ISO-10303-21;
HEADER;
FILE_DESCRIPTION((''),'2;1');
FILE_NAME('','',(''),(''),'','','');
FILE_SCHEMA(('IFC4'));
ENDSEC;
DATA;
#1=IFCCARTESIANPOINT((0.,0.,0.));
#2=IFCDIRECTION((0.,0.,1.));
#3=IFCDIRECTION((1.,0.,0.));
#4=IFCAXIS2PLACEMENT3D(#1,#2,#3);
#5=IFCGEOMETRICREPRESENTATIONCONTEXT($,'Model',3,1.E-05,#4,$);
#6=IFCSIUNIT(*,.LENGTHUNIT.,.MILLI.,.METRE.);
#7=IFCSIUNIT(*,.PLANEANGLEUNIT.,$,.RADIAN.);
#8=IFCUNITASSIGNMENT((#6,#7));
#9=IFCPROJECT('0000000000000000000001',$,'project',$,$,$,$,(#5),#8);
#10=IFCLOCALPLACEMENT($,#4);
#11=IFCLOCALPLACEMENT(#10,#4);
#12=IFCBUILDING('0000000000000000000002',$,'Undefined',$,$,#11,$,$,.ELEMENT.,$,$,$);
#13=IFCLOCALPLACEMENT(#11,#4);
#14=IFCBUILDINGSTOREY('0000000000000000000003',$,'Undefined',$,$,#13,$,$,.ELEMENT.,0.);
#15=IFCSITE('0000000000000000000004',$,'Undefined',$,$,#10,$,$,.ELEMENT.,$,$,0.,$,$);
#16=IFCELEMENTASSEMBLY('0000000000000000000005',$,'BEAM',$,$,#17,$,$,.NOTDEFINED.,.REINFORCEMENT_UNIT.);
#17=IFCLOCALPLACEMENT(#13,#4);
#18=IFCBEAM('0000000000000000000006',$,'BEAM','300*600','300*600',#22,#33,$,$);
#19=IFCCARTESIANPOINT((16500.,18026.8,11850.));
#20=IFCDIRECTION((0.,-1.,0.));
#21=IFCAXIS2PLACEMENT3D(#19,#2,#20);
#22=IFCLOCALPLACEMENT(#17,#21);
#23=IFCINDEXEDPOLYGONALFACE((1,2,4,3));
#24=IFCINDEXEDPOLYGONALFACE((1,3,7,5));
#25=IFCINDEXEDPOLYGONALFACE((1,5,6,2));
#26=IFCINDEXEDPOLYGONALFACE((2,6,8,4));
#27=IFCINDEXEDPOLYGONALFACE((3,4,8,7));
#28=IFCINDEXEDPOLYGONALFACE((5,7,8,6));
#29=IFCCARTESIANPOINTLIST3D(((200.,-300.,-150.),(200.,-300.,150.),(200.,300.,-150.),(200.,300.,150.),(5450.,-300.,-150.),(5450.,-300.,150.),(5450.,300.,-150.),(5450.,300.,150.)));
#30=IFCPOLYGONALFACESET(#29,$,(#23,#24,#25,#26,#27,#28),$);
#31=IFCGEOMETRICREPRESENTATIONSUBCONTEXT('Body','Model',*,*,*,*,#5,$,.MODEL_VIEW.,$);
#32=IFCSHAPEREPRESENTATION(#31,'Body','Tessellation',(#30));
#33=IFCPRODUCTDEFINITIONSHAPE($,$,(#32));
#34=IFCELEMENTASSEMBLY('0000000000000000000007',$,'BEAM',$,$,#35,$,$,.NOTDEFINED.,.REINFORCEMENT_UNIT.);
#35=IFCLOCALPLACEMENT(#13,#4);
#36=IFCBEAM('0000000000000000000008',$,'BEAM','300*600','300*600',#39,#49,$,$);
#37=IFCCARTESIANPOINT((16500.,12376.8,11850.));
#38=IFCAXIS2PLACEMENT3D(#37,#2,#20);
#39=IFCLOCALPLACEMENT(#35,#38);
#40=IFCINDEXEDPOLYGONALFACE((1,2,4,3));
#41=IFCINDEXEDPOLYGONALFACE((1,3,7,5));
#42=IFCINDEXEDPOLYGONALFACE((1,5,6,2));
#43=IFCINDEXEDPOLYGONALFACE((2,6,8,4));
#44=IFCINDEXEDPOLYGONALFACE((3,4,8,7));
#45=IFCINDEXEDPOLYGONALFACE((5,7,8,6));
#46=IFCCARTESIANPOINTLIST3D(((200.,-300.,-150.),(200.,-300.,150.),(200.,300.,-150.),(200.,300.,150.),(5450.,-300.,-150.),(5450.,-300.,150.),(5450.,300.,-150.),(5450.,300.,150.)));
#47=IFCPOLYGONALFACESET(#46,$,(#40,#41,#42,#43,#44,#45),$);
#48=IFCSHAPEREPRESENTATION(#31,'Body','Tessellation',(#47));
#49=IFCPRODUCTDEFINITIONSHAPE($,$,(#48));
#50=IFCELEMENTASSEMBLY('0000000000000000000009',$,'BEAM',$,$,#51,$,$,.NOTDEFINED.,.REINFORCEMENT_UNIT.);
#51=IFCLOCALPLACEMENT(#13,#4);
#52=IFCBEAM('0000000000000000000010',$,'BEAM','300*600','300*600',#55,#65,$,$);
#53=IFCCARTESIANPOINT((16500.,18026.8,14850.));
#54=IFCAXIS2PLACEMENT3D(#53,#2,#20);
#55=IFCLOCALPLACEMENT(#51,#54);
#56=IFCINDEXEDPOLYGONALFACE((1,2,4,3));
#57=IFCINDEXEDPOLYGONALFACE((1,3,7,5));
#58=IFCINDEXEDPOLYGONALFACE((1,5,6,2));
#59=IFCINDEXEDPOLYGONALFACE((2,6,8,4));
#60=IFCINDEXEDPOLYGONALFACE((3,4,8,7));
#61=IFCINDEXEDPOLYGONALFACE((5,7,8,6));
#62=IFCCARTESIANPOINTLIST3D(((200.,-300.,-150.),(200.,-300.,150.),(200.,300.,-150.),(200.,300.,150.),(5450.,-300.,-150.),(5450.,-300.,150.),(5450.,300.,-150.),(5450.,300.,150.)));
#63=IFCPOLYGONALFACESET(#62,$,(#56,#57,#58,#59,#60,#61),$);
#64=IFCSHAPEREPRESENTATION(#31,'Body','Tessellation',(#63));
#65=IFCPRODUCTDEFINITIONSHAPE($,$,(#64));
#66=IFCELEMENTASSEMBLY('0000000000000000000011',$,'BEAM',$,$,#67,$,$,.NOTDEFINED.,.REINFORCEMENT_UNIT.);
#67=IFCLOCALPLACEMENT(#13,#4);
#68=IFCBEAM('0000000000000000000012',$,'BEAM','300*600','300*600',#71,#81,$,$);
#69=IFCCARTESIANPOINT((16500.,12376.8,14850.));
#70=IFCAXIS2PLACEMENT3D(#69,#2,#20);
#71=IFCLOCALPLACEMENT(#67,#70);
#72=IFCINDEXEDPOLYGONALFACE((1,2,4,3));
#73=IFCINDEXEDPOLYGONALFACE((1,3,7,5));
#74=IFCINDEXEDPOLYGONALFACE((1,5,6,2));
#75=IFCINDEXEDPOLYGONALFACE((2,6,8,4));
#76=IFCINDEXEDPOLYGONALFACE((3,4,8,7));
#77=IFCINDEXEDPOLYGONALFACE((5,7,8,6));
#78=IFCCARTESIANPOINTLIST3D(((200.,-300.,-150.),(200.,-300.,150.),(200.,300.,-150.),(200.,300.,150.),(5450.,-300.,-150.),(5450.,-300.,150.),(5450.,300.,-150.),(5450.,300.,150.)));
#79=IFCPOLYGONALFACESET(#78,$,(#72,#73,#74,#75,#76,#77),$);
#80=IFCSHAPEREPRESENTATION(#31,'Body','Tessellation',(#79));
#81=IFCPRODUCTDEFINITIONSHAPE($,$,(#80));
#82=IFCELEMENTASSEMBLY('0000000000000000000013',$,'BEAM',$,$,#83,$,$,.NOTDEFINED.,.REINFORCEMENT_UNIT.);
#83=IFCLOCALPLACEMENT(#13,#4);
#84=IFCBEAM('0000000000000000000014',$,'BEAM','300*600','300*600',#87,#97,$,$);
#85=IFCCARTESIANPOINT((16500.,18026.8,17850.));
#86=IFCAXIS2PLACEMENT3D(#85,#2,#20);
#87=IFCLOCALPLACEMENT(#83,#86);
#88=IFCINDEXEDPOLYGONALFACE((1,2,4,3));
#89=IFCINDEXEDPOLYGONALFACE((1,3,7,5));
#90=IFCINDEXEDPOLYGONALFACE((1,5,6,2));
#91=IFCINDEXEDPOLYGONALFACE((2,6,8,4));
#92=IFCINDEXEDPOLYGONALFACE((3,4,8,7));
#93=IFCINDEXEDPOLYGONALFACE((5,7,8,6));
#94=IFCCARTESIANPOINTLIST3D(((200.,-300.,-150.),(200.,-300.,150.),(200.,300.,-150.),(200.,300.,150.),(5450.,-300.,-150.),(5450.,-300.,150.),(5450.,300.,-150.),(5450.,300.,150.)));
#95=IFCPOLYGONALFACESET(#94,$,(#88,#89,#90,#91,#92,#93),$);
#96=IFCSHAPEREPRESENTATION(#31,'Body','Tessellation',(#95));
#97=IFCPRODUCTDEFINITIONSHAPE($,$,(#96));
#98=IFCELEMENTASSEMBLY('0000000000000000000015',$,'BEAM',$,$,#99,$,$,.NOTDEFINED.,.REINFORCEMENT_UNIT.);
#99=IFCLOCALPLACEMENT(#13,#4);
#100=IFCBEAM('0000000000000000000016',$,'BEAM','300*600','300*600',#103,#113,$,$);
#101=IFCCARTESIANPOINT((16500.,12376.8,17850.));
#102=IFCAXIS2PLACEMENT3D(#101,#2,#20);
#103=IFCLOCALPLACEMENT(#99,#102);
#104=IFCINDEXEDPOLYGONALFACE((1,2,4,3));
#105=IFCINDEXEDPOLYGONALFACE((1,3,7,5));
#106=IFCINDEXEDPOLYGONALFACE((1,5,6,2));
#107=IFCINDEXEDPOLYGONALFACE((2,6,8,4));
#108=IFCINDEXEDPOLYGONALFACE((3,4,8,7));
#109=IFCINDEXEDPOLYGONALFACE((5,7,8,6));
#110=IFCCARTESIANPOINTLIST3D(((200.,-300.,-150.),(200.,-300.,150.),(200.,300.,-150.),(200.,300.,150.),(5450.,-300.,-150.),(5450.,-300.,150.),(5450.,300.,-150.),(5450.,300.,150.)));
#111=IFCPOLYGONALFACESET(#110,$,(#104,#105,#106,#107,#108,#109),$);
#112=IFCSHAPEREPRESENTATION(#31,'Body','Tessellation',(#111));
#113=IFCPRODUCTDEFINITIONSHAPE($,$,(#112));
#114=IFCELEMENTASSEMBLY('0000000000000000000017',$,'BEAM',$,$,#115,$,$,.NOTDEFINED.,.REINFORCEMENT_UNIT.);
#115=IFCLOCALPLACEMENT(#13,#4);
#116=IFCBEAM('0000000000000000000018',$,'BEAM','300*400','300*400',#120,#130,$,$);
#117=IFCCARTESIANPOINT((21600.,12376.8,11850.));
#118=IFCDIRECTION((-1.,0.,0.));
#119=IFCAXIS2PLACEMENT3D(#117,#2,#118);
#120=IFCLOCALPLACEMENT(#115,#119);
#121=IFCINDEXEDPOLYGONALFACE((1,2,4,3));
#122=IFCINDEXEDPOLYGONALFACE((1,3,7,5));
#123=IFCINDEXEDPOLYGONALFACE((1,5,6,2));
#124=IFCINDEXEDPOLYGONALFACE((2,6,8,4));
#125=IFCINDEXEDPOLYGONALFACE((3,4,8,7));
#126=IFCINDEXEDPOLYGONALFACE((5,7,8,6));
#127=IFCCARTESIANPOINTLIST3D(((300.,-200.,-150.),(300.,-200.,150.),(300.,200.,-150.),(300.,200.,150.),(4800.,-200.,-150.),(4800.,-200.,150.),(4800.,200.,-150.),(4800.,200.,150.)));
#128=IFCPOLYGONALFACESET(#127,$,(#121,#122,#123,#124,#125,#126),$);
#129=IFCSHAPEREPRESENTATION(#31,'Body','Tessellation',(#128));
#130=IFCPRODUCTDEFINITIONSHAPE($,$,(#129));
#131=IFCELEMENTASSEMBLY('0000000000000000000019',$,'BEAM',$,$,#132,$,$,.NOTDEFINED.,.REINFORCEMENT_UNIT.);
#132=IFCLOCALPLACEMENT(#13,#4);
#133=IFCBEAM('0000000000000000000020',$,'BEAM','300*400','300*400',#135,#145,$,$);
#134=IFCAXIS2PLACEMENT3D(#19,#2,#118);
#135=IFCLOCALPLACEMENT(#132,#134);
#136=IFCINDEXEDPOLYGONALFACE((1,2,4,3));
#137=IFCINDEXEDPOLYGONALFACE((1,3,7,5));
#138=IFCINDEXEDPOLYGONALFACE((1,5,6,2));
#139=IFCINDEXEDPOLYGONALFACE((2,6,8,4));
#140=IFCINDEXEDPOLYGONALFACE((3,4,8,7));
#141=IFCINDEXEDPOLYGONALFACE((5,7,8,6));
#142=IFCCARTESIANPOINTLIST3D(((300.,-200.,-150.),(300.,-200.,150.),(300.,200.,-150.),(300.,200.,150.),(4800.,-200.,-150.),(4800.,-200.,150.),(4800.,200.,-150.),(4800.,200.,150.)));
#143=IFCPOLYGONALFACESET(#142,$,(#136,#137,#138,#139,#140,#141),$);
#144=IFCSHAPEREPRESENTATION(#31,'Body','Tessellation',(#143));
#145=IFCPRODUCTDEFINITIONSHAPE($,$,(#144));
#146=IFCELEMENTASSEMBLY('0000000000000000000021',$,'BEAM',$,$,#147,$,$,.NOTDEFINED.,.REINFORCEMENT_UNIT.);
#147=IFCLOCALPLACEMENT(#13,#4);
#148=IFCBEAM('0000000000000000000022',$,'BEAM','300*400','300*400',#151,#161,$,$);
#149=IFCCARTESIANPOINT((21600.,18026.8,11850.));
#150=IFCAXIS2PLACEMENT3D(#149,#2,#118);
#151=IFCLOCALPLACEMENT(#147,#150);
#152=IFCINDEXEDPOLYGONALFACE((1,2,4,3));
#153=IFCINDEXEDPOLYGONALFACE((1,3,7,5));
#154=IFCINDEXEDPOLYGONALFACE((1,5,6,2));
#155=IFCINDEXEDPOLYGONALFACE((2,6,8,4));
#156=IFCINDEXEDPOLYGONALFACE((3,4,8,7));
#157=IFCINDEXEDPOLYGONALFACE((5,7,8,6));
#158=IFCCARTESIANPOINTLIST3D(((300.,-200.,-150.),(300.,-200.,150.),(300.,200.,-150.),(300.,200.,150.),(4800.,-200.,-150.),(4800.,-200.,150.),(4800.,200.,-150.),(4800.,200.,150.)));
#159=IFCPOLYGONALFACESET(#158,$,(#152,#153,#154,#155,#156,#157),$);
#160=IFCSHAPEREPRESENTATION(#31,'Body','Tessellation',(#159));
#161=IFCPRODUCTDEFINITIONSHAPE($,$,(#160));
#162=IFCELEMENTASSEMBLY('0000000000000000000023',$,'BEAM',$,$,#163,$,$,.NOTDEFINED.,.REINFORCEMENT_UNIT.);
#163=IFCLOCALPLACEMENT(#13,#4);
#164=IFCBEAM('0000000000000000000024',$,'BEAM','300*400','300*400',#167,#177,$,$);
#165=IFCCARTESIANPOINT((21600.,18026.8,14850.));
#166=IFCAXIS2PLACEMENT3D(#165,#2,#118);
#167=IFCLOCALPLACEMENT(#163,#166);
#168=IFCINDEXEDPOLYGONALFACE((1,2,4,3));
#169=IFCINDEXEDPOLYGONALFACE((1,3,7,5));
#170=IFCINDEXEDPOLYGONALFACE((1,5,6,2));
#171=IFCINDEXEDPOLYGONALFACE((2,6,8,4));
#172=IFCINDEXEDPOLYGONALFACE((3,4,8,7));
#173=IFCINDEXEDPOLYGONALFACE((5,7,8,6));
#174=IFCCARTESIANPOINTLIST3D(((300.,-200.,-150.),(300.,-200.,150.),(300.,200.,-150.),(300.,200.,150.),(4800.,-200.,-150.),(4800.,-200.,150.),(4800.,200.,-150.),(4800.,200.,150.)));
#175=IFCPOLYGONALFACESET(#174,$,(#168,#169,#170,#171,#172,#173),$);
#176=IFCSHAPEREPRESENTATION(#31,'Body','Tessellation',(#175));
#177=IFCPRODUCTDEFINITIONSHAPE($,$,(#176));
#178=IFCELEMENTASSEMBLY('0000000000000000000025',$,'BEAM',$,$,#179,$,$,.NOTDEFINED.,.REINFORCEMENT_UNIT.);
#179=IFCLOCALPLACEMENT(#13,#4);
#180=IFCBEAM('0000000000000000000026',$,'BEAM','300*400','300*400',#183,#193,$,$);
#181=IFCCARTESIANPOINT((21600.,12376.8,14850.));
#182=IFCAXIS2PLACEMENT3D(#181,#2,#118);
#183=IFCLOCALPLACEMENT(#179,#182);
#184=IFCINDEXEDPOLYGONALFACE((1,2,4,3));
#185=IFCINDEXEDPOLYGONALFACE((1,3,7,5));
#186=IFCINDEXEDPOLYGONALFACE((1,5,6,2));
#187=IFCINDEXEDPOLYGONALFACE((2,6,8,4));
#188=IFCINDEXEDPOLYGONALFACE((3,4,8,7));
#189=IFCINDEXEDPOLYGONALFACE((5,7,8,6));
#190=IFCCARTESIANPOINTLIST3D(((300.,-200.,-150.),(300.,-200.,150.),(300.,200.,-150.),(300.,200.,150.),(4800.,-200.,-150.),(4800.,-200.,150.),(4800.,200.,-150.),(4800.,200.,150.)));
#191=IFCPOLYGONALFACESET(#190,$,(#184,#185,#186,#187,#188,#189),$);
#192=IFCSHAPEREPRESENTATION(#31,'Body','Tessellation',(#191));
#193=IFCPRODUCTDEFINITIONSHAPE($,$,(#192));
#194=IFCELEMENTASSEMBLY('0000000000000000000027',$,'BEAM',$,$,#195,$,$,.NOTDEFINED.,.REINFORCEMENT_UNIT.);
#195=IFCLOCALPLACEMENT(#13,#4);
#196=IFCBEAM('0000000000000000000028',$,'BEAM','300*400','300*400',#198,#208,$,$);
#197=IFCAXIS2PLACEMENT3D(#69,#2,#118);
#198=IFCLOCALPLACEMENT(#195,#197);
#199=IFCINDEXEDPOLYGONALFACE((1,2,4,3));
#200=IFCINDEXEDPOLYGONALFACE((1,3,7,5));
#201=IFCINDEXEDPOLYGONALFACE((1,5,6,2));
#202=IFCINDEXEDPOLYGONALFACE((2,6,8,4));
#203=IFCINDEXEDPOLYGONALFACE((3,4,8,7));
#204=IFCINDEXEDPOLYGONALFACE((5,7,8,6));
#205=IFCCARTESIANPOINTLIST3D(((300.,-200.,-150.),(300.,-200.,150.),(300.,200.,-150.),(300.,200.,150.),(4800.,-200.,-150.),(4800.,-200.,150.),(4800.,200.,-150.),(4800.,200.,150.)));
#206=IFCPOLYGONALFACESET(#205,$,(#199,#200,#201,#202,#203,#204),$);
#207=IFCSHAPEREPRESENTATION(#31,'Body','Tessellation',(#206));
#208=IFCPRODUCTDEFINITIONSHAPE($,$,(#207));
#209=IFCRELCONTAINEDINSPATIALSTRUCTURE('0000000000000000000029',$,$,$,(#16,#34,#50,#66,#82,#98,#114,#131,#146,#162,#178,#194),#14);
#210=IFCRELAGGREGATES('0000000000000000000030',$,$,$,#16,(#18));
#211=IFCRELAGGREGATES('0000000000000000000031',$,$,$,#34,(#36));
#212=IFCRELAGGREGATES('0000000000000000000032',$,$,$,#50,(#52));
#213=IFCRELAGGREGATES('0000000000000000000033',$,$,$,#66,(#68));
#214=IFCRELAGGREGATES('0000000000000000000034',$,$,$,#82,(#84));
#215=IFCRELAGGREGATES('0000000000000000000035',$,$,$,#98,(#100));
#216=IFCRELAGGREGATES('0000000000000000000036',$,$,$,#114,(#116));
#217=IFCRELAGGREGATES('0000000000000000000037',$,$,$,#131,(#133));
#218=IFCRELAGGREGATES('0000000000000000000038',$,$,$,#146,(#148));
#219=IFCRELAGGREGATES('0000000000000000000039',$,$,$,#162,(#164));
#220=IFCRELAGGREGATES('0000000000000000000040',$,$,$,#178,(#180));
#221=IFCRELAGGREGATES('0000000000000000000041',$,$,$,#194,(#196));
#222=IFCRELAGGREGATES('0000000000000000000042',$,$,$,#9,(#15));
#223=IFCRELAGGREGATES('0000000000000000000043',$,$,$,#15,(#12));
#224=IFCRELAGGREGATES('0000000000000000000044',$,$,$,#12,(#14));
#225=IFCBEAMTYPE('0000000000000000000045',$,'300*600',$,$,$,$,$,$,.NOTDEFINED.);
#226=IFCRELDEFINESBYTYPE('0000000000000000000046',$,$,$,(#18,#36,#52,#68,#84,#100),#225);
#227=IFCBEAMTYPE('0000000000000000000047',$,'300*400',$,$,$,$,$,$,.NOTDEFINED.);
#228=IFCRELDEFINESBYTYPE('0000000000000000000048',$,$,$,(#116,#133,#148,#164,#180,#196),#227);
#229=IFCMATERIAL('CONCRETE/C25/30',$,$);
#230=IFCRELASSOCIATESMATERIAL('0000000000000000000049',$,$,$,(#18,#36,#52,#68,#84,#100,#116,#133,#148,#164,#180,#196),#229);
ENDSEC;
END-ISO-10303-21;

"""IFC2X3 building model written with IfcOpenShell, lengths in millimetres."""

from ifc_helpers import new_model, si_unit, frame, origin_with_axes, origin_2d_with_axis, place, context, subcontext, project, spatial, rectangle, extrude, material, type_object, element, aggregate, save


model = new_model("IFC2X3")

# Units and contexts
model_context = context("Model", 3, precision=1e-05, world=origin_with_axes())
body_context = subcontext(model_context, "Body", "Model", "MODEL_VIEW")
ifc_project = project(units=[si_unit("LENGTHUNIT", "METRE", prefix="MILLI"), si_unit("PLANEANGLEUNIT", "RADIAN")], contexts=[model_context])

# Site, building, storey
site_placement = place(None, origin_with_axes())
site = spatial("IfcSite", under=ifc_project, at=site_placement, Name="Undefined", CompositionType="ELEMENT", RefElevation=0.0)
building_placement = place(site_placement, origin_with_axes())
building = spatial("IfcBuilding", under=site, at=building_placement, Name="Undefined", CompositionType="ELEMENT")
storey_placement = place(building_placement, origin_with_axes())
storey = spatial("IfcBuildingStorey", under=building, at=storey_placement, Name="Undefined", CompositionType="ELEMENT", Elevation=0.0)

# Shared definitions
ifc_material = material(Name="CONCRETE/C25/30")

# Element assemblies, beams
assembly_1_placement = place(storey_placement, origin_with_axes())
assembly_1 = element("IfcElementAssembly", 1, at=assembly_1_placement, inside=storey, Name="BEAM", AssemblyPlace="NOTDEFINED", PredefinedType="REINFORCEMENT_UNIT")
beam_type_1 = type_object("IfcBeamType", Name="300*600", PredefinedType="NOTDEFINED")
beam_1_placement = place(assembly_1_placement, frame((16500.0, 18026.8, 11850.0), z_axis=(0.0, 0.0, 1.0), x_axis=(0.0, -1.0, 0.0)))
beam_1 = element("IfcBeam", 2, at=beam_1_placement, type_object=beam_type_1, material=ifc_material, Name="BEAM", Description="300*600", ObjectType="300*600", context=body_context, shape_type="SweptSolid", body=[
    extrude(rectangle(XDim=600.0, YDim=300.0, at=origin_2d_with_axis()), frame((5450.0, 0.0, 0.0), z_axis=(-1.0, 0.0, 0.0), x_axis=(0.0, -1.0, 0.0)), (0.0, 0.0, 1.0), 5250.0),
])
aggregate(assembly_1, [beam_1])
assembly_2_placement = place(storey_placement, origin_with_axes())
assembly_2 = element("IfcElementAssembly", 3, at=assembly_2_placement, inside=storey, Name="BEAM", AssemblyPlace="NOTDEFINED", PredefinedType="REINFORCEMENT_UNIT")
beam_2_placement = place(assembly_2_placement, frame((16500.0, 12376.8, 11850.0), z_axis=(0.0, 0.0, 1.0), x_axis=(0.0, -1.0, 0.0)))
beam_2 = element("IfcBeam", 4, at=beam_2_placement, type_object=beam_type_1, material=ifc_material, Name="BEAM", Description="300*600", ObjectType="300*600", context=body_context, shape_type="SweptSolid", body=[
    extrude(rectangle(XDim=600.0, YDim=300.0, at=origin_2d_with_axis()), frame((5450.0, 0.0, 0.0), z_axis=(-1.0, 0.0, 0.0), x_axis=(0.0, -1.0, 0.0)), (0.0, 0.0, 1.0), 5250.0),
])
aggregate(assembly_2, [beam_2])
assembly_3_placement = place(storey_placement, origin_with_axes())
assembly_3 = element("IfcElementAssembly", 5, at=assembly_3_placement, inside=storey, Name="BEAM", AssemblyPlace="NOTDEFINED", PredefinedType="REINFORCEMENT_UNIT")
beam_3_placement = place(assembly_3_placement, frame((16500.0, 18026.8, 14850.0), z_axis=(0.0, 0.0, 1.0), x_axis=(0.0, -1.0, 0.0)))
beam_3 = element("IfcBeam", 6, at=beam_3_placement, type_object=beam_type_1, material=ifc_material, Name="BEAM", Description="300*600", ObjectType="300*600", context=body_context, shape_type="SweptSolid", body=[
    extrude(rectangle(XDim=600.0, YDim=300.0, at=origin_2d_with_axis()), frame((5450.0, 0.0, 0.0), z_axis=(-1.0, 0.0, 0.0), x_axis=(0.0, -1.0, 0.0)), (0.0, 0.0, 1.0), 5250.0),
])
aggregate(assembly_3, [beam_3])
assembly_4_placement = place(storey_placement, origin_with_axes())
assembly_4 = element("IfcElementAssembly", 7, at=assembly_4_placement, inside=storey, Name="BEAM", AssemblyPlace="NOTDEFINED", PredefinedType="REINFORCEMENT_UNIT")
beam_4_placement = place(assembly_4_placement, frame((16500.0, 12376.8, 14850.0), z_axis=(0.0, 0.0, 1.0), x_axis=(0.0, -1.0, 0.0)))
beam_4 = element("IfcBeam", 8, at=beam_4_placement, type_object=beam_type_1, material=ifc_material, Name="BEAM", Description="300*600", ObjectType="300*600", context=body_context, shape_type="SweptSolid", body=[
    extrude(rectangle(XDim=600.0, YDim=300.0, at=origin_2d_with_axis()), frame((5450.0, 0.0, 0.0), z_axis=(-1.0, 0.0, 0.0), x_axis=(0.0, -1.0, 0.0)), (0.0, 0.0, 1.0), 5250.0),
])
aggregate(assembly_4, [beam_4])
assembly_5_placement = place(storey_placement, origin_with_axes())
assembly_5 = element("IfcElementAssembly", 9, at=assembly_5_placement, inside=storey, Name="BEAM", AssemblyPlace="NOTDEFINED", PredefinedType="REINFORCEMENT_UNIT")
beam_5_placement = place(assembly_5_placement, frame((16500.0, 18026.8, 17850.0), z_axis=(0.0, 0.0, 1.0), x_axis=(0.0, -1.0, 0.0)))
beam_5 = element("IfcBeam", 10, at=beam_5_placement, type_object=beam_type_1, material=ifc_material, Name="BEAM", Description="300*600", ObjectType="300*600", context=body_context, shape_type="SweptSolid", body=[
    extrude(rectangle(XDim=600.0, YDim=300.0, at=origin_2d_with_axis()), frame((5450.0, 0.0, 0.0), z_axis=(-1.0, 0.0, 0.0), x_axis=(0.0, -1.0, 0.0)), (0.0, 0.0, 1.0), 5250.0),
])
aggregate(assembly_5, [beam_5])
assembly_6_placement = place(storey_placement, origin_with_axes())
assembly_6 = element("IfcElementAssembly", 11, at=assembly_6_placement, inside=storey, Name="BEAM", AssemblyPlace="NOTDEFINED", PredefinedType="REINFORCEMENT_UNIT")
beam_6_placement = place(assembly_6_placement, frame((16500.0, 12376.8, 17850.0), z_axis=(0.0, 0.0, 1.0), x_axis=(0.0, -1.0, 0.0)))
beam_6 = element("IfcBeam", 12, at=beam_6_placement, type_object=beam_type_1, material=ifc_material, Name="BEAM", Description="300*600", ObjectType="300*600", context=body_context, shape_type="SweptSolid", body=[
    extrude(rectangle(XDim=600.0, YDim=300.0, at=origin_2d_with_axis()), frame((5450.0, 0.0, 0.0), z_axis=(-1.0, 0.0, 0.0), x_axis=(0.0, -1.0, 0.0)), (0.0, 0.0, 1.0), 5250.0),
])
aggregate(assembly_6, [beam_6])
assembly_7_placement = place(storey_placement, origin_with_axes())
assembly_7 = element("IfcElementAssembly", 13, at=assembly_7_placement, inside=storey, Name="BEAM", AssemblyPlace="NOTDEFINED", PredefinedType="REINFORCEMENT_UNIT")
beam_type_2 = type_object("IfcBeamType", Name="300*400", PredefinedType="NOTDEFINED")
beam_7_placement = place(assembly_7_placement, frame((21600.0, 12376.8, 11850.0), z_axis=(0.0, 0.0, 1.0), x_axis=(-1.0, 0.0, 0.0)))
beam_7 = element("IfcBeam", 14, at=beam_7_placement, type_object=beam_type_2, material=ifc_material, Name="BEAM", Description="300*400", ObjectType="300*400", context=body_context, shape_type="SweptSolid", body=[
    extrude(rectangle(XDim=400.0, YDim=300.0, at=origin_2d_with_axis()), frame((4800.0, 0.0, 0.0), z_axis=(-1.0, 0.0, 0.0), x_axis=(0.0, -1.0, 0.0)), (0.0, 0.0, 1.0), 4500.0),
])
aggregate(assembly_7, [beam_7])
assembly_8_placement = place(storey_placement, origin_with_axes())
assembly_8 = element("IfcElementAssembly", 15, at=assembly_8_placement, inside=storey, Name="BEAM", AssemblyPlace="NOTDEFINED", PredefinedType="REINFORCEMENT_UNIT")
beam_8_placement = place(assembly_8_placement, frame((16500.0, 18026.8, 11850.0), z_axis=(0.0, 0.0, 1.0), x_axis=(-1.0, 0.0, 0.0)))
beam_8 = element("IfcBeam", 16, at=beam_8_placement, type_object=beam_type_2, material=ifc_material, Name="BEAM", Description="300*400", ObjectType="300*400", context=body_context, shape_type="SweptSolid", body=[
    extrude(rectangle(XDim=400.0, YDim=300.0, at=origin_2d_with_axis()), frame((4800.0, 0.0, 0.0), z_axis=(-1.0, 0.0, 0.0), x_axis=(0.0, -1.0, 0.0)), (0.0, 0.0, 1.0), 4500.0),
])
aggregate(assembly_8, [beam_8])
assembly_9_placement = place(storey_placement, origin_with_axes())
assembly_9 = element("IfcElementAssembly", 17, at=assembly_9_placement, inside=storey, Name="BEAM", AssemblyPlace="NOTDEFINED", PredefinedType="REINFORCEMENT_UNIT")
beam_9_placement = place(assembly_9_placement, frame((21600.0, 18026.8, 11850.0), z_axis=(0.0, 0.0, 1.0), x_axis=(-1.0, 0.0, 0.0)))
beam_9 = element("IfcBeam", 18, at=beam_9_placement, type_object=beam_type_2, material=ifc_material, Name="BEAM", Description="300*400", ObjectType="300*400", context=body_context, shape_type="SweptSolid", body=[
    extrude(rectangle(XDim=400.0, YDim=300.0, at=origin_2d_with_axis()), frame((4800.0, 0.0, 0.0), z_axis=(-1.0, 0.0, 0.0), x_axis=(0.0, -1.0, 0.0)), (0.0, 0.0, 1.0), 4500.0),
])
aggregate(assembly_9, [beam_9])
assembly_10_placement = place(storey_placement, origin_with_axes())
assembly_10 = element("IfcElementAssembly", 19, at=assembly_10_placement, inside=storey, Name="BEAM", AssemblyPlace="NOTDEFINED", PredefinedType="REINFORCEMENT_UNIT")
beam_10_placement = place(assembly_10_placement, frame((21600.0, 18026.8, 14850.0), z_axis=(0.0, 0.0, 1.0), x_axis=(-1.0, 0.0, 0.0)))
beam_10 = element("IfcBeam", 20, at=beam_10_placement, type_object=beam_type_2, material=ifc_material, Name="BEAM", Description="300*400", ObjectType="300*400", context=body_context, shape_type="SweptSolid", body=[
    extrude(rectangle(XDim=400.0, YDim=300.0, at=origin_2d_with_axis()), frame((4800.0, 0.0, 0.0), z_axis=(-1.0, 0.0, 0.0), x_axis=(0.0, -1.0, 0.0)), (0.0, 0.0, 1.0), 4500.0),
])
aggregate(assembly_10, [beam_10])
assembly_11_placement = place(storey_placement, origin_with_axes())
assembly_11 = element("IfcElementAssembly", 21, at=assembly_11_placement, inside=storey, Name="BEAM", AssemblyPlace="NOTDEFINED", PredefinedType="REINFORCEMENT_UNIT")
beam_11_placement = place(assembly_11_placement, frame((21600.0, 12376.8, 14850.0), z_axis=(0.0, 0.0, 1.0), x_axis=(-1.0, 0.0, 0.0)))
beam_11 = element("IfcBeam", 22, at=beam_11_placement, type_object=beam_type_2, material=ifc_material, Name="BEAM", Description="300*400", ObjectType="300*400", context=body_context, shape_type="SweptSolid", body=[
    extrude(rectangle(XDim=400.0, YDim=300.0, at=origin_2d_with_axis()), frame((4800.0, 0.0, 0.0), z_axis=(-1.0, 0.0, 0.0), x_axis=(0.0, -1.0, 0.0)), (0.0, 0.0, 1.0), 4500.0),
])
aggregate(assembly_11, [beam_11])
assembly_12_placement = place(storey_placement, origin_with_axes())
assembly_12 = element("IfcElementAssembly", 23, at=assembly_12_placement, inside=storey, Name="BEAM", AssemblyPlace="NOTDEFINED", PredefinedType="REINFORCEMENT_UNIT")
beam_12_placement = place(assembly_12_placement, frame((16500.0, 12376.8, 14850.0), z_axis=(0.0, 0.0, 1.0), x_axis=(-1.0, 0.0, 0.0)))
beam_12 = element("IfcBeam", 24, at=beam_12_placement, type_object=beam_type_2, material=ifc_material, Name="BEAM", Description="300*400", ObjectType="300*400", context=body_context, shape_type="SweptSolid", body=[
    extrude(rectangle(XDim=400.0, YDim=300.0, at=origin_2d_with_axis()), frame((4800.0, 0.0, 0.0), z_axis=(-1.0, 0.0, 0.0), x_axis=(0.0, -1.0, 0.0)), (0.0, 0.0, 1.0), 4500.0),
])
aggregate(assembly_12, [beam_12])

save(model, "model.ifc")
